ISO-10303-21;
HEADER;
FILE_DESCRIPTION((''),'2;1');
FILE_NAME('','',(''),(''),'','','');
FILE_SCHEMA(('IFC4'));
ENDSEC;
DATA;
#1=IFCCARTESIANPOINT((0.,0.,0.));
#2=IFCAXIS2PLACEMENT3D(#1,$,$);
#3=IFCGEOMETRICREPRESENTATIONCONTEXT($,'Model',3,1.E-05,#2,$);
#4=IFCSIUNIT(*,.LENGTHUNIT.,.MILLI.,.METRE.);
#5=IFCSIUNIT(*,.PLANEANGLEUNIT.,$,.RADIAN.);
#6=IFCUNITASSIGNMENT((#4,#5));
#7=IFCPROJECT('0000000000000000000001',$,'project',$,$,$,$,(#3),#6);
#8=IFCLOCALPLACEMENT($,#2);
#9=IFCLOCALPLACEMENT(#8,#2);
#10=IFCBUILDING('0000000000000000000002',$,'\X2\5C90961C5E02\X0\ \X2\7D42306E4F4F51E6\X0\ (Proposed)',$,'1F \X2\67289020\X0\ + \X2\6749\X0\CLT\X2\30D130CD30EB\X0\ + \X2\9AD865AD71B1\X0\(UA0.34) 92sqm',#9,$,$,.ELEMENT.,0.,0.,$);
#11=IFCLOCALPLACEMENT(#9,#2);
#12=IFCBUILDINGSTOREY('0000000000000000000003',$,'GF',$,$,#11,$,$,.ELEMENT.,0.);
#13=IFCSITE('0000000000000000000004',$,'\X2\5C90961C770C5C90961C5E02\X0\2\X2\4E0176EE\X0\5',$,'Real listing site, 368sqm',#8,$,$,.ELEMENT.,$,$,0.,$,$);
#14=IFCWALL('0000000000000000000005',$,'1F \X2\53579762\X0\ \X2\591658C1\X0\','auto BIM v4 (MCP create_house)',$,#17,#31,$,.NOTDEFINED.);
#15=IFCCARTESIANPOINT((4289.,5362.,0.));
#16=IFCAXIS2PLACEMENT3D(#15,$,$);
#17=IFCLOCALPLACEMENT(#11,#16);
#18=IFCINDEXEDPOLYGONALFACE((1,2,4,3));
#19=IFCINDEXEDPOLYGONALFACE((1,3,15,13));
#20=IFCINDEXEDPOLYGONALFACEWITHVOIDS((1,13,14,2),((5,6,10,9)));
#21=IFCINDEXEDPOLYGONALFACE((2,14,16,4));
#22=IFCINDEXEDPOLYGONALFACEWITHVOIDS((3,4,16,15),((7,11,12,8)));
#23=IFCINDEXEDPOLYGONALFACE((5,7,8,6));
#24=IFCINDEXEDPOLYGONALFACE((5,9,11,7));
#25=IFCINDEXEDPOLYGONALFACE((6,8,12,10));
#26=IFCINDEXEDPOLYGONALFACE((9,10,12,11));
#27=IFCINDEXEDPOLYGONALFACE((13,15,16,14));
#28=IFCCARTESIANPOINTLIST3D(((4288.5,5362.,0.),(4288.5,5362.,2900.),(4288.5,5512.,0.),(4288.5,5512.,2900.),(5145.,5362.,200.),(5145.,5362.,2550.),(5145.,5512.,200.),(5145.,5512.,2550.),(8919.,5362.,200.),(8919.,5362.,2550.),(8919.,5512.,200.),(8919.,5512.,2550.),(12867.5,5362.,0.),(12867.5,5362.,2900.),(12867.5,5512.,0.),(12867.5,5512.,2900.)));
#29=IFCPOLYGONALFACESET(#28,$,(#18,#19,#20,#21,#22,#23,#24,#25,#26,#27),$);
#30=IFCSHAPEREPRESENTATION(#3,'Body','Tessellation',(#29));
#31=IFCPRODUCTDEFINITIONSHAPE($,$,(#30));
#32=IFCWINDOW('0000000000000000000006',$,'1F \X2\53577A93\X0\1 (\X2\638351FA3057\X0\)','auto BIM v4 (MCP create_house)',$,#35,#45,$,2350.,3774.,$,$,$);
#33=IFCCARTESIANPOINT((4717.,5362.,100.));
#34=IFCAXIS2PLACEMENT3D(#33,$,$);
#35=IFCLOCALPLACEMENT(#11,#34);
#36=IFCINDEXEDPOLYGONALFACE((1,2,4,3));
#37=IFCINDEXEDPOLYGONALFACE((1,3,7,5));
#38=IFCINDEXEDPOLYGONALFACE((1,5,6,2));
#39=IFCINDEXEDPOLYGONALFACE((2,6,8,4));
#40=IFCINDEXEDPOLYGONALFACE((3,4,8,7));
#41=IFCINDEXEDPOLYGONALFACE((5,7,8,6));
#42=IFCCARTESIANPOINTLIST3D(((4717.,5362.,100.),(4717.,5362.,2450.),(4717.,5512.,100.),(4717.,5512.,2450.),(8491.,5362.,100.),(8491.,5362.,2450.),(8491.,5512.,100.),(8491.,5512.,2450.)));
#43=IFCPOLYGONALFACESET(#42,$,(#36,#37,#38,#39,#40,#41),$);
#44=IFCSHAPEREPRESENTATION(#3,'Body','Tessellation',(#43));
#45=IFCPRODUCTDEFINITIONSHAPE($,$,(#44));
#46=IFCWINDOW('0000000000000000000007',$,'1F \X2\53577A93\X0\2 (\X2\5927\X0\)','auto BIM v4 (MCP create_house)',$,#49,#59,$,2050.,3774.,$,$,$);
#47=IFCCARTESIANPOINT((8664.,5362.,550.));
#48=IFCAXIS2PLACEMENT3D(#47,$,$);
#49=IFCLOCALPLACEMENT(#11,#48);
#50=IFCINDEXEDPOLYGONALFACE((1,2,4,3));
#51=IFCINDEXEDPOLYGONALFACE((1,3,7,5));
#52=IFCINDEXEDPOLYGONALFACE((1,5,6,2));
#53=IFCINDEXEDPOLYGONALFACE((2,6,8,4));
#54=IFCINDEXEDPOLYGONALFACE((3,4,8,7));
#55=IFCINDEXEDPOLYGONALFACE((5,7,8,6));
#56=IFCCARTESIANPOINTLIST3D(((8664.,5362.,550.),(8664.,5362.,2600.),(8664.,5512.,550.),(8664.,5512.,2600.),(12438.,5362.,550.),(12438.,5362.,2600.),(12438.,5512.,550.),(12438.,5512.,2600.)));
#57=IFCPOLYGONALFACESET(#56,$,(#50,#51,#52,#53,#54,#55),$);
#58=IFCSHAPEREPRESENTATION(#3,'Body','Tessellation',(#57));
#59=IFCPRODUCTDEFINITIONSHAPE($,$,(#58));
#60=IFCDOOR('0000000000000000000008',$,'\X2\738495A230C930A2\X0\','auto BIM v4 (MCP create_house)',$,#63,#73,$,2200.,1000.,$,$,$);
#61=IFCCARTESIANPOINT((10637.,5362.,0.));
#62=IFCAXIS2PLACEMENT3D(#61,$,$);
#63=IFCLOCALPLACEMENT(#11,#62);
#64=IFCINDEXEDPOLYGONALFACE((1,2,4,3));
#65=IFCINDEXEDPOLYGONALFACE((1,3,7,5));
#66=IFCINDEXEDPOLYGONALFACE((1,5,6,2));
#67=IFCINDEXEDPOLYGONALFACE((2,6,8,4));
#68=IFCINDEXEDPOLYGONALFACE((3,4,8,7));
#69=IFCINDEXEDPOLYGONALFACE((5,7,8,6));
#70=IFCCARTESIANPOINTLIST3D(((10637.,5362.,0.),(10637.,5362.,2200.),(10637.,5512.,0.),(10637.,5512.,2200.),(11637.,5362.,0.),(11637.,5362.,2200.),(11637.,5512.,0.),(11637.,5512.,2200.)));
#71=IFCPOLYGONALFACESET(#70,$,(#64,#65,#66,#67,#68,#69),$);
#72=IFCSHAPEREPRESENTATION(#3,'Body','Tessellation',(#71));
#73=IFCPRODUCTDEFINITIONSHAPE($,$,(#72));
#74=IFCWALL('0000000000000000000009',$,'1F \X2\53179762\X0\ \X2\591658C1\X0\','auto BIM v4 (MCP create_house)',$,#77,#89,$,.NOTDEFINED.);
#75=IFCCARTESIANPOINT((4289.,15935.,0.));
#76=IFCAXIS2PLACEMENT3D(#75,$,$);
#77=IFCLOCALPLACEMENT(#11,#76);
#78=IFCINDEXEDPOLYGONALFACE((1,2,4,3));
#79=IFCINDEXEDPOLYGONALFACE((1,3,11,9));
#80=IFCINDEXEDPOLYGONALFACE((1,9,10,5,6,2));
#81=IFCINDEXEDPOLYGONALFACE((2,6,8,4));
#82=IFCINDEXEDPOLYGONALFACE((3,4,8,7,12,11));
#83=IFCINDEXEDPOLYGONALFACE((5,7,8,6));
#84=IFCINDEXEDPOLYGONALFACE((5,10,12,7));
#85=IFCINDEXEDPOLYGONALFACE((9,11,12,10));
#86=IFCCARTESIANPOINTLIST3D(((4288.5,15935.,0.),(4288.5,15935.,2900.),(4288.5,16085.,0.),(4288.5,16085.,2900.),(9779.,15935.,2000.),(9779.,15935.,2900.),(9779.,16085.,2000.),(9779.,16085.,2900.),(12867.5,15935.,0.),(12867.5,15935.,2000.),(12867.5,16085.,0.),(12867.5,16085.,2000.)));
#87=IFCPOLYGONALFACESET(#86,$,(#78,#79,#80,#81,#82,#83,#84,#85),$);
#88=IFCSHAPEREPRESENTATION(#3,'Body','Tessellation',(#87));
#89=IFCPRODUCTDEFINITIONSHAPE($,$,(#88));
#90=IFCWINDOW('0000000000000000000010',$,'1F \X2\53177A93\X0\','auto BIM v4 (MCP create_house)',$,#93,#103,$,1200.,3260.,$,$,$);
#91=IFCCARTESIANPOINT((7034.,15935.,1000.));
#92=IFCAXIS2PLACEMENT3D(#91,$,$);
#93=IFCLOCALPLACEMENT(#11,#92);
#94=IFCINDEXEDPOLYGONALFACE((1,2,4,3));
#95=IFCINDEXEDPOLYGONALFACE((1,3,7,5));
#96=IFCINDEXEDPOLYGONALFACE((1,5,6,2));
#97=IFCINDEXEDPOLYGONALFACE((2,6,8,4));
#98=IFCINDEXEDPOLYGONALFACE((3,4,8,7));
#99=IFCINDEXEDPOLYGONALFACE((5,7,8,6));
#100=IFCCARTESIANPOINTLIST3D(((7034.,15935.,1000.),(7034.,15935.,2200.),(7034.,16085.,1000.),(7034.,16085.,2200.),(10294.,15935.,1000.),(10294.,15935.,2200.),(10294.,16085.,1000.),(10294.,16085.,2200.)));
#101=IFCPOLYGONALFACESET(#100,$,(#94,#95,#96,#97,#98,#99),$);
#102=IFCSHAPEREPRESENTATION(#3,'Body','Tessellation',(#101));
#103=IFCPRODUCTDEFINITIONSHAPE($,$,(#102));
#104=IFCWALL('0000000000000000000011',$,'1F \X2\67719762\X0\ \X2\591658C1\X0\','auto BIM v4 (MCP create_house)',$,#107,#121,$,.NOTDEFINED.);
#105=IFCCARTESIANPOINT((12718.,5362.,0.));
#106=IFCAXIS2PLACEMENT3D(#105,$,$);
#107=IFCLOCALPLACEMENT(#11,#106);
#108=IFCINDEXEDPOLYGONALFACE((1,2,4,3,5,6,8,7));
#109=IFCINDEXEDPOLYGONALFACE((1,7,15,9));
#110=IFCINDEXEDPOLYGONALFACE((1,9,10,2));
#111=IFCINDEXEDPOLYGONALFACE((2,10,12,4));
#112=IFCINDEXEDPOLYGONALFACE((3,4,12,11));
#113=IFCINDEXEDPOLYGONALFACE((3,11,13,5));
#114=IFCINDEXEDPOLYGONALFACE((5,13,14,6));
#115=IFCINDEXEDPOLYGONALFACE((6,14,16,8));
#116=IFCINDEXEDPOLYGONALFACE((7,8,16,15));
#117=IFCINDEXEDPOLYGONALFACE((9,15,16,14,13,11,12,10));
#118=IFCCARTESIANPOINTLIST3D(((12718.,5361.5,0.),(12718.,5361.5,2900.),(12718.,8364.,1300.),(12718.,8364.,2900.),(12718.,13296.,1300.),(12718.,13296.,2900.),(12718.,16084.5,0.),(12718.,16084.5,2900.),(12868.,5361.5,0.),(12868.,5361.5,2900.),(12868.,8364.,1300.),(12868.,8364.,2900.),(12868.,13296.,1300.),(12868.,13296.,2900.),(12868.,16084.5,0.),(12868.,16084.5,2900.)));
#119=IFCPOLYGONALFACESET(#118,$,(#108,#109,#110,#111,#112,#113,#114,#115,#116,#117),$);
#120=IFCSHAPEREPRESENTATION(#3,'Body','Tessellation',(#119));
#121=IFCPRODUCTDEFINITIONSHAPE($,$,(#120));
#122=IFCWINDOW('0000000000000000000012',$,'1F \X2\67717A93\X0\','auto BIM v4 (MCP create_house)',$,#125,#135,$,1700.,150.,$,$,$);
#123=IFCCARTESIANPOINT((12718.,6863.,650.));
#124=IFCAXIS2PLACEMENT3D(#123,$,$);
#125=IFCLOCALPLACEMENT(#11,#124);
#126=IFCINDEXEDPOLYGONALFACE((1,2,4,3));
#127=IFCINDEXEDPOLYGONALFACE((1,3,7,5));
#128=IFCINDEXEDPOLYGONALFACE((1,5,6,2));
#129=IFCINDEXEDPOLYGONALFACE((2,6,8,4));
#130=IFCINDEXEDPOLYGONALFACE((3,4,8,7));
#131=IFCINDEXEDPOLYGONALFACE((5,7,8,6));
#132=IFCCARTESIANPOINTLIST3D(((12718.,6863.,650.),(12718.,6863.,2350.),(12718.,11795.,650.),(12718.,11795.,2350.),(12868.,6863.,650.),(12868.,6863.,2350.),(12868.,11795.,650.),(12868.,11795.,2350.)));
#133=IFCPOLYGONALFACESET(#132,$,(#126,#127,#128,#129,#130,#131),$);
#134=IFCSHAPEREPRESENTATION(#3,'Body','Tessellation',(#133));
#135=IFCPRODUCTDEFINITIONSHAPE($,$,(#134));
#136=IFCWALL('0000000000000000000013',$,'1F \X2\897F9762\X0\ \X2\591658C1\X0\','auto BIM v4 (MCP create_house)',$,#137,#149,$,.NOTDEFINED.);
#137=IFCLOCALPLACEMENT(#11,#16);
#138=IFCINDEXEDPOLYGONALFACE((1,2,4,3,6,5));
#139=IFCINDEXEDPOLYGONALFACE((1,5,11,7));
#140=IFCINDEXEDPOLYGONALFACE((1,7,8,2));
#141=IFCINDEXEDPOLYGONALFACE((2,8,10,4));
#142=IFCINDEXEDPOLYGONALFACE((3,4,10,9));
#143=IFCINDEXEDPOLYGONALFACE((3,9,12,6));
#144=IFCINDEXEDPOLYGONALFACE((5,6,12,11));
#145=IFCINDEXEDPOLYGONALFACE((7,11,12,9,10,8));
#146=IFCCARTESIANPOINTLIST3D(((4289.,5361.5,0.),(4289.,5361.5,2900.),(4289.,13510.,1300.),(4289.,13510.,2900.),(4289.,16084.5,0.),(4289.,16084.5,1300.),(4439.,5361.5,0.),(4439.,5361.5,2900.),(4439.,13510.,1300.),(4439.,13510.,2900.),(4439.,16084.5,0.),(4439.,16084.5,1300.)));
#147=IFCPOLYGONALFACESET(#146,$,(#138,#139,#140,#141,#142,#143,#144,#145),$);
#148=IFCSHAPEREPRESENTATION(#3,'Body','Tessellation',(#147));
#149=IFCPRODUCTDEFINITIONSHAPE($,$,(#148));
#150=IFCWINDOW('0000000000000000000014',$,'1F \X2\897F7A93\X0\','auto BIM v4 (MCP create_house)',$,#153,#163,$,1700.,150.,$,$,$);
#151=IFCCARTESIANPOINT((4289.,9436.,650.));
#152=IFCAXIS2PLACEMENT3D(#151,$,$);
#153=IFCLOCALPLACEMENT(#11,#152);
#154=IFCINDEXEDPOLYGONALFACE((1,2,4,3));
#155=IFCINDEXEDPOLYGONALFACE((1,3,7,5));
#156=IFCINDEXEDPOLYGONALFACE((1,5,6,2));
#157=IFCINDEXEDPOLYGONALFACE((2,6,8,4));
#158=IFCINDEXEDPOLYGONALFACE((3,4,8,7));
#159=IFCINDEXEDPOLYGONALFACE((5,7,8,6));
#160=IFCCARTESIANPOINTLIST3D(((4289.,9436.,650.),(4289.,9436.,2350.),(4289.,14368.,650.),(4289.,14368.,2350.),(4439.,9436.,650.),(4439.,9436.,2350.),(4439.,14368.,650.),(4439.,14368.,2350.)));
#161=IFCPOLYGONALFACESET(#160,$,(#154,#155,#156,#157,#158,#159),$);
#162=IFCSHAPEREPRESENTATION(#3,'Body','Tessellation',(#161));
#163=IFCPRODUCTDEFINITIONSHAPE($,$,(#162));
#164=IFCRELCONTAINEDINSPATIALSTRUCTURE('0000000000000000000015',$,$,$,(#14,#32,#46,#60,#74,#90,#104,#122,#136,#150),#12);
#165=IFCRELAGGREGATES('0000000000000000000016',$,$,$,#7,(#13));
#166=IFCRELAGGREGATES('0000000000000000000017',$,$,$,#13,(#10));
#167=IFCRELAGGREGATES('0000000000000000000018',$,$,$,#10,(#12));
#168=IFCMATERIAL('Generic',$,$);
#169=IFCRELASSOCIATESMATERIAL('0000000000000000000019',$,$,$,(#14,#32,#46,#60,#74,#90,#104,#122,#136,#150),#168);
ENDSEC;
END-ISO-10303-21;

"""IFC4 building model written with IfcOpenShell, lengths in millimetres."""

from ifc_helpers import new_model, si_unit, frame, frame_2d, origin, place, context, project, spatial, rectangle, extrude, material, element, fill, save


model = new_model("IFC4")

# Units and contexts
model_context = context("Model", 3, precision=1e-05, world=origin())
ifc_project = project(units=[si_unit("LENGTHUNIT", "METRE", prefix="MILLI"), si_unit("PLANEANGLEUNIT", "RADIAN")], contexts=[model_context])

# Site, building, storey
site_placement = place(None, origin())
site = spatial("IfcSite", under=ifc_project, at=site_placement, Name="岐阜県岐阜市2丁目5", ObjectType="Real listing site, 368sqm", CompositionType="ELEMENT", RefElevation=0.0)
building_placement = place(site_placement, origin())
building = spatial("IfcBuilding", under=site, at=building_placement, Name="岐阜市 終の住処 (Proposed)", ObjectType="1F 木造 + 杉CLTパネル + 高断熱(UA0.34) 92sqm", CompositionType="ELEMENT", ElevationOfRefHeight=0.0, ElevationOfTerrain=0.0)
storey_placement = place(building_placement, origin())
storey = spatial("IfcBuildingStorey", under=building, at=storey_placement, Name="GF", CompositionType="ELEMENT", Elevation=0.0)

# Shared definitions
ifc_material = material(Name="Generic")

# Wall, openings, windows, door
wall_1_placement = place(storey_placement, frame((4289.0, 5362.0, 0.0)))
wall_1 = element("IfcWall", 1, at=wall_1_placement, inside=storey, material=ifc_material, Name="1F 南面 外壁", Description="auto BIM v4 (MCP create_house)", PredefinedType="NOTDEFINED", context=model_context, shape_type="SweptSolid", body=[
    extrude(rectangle(XDim=8579.0, YDim=150.0, at=frame_2d((4289.0, 75.0))), frame((4289.0, 5362.0, 0.0)), (0.0, 0.0, 1.0), 2900.0),
])
opening_1_placement = place(storey_placement, frame((4717.0, 5362.0, 100.0)))
opening_1 = element("IfcOpeningElement", 2, at=opening_1_placement, cuts=wall_1, PredefinedType="NOTDEFINED", context=model_context, shape_type="SweptSolid", body=[
    extrude(rectangle(XDim=3774.0, YDim=150.0, at=frame_2d((1887.0, 75.0))), frame((4717.0, 5362.0, 100.0)), (0.0, 0.0, 1.0), 2350.0),
])
opening_2_placement = place(storey_placement, frame((8664.0, 5362.0, 550.0)))
opening_2 = element("IfcOpeningElement", 3, at=opening_2_placement, cuts=wall_1, PredefinedType="NOTDEFINED", context=model_context, shape_type="SweptSolid", body=[
    extrude(rectangle(XDim=3774.0, YDim=150.0, at=frame_2d((1887.0, 75.0))), frame((8664.0, 5362.0, 550.0)), (0.0, 0.0, 1.0), 2050.0),
])
opening_3_placement = place(storey_placement, frame((10637.0, 5362.0, 0.0)))
opening_3 = element("IfcOpeningElement", 4, at=opening_3_placement, cuts=wall_1, PredefinedType="NOTDEFINED", context=model_context, shape_type="SweptSolid", body=[
    extrude(rectangle(XDim=1000.0, YDim=150.0, at=frame_2d((500.0, 75.0))), frame((10637.0, 5362.0, 0.0)), (0.0, 0.0, 1.0), 2200.0),
])
window_1_placement = place(storey_placement, frame((4717.0, 5362.0, 100.0)))
window_1 = element("IfcWindow", 5, at=window_1_placement, inside=storey, material=ifc_material, Name="1F 南窓1 (掃出し)", Description="auto BIM v4 (MCP create_house)", OverallHeight=2350.0, OverallWidth=3774.0, context=model_context, shape_type="SweptSolid", body=[
    extrude(rectangle(XDim=3774.0, YDim=150.0, at=frame_2d((1887.0, 75.0))), frame((4717.0, 5362.0, 100.0)), (0.0, 0.0, 1.0), 2350.0),
])
fill(opening_1, window_1)
window_2_placement = place(storey_placement, frame((8664.0, 5362.0, 550.0)))
window_2 = element("IfcWindow", 6, at=window_2_placement, inside=storey, material=ifc_material, Name="1F 南窓2 (大)", Description="auto BIM v4 (MCP create_house)", OverallHeight=2050.0, OverallWidth=3774.0, context=model_context, shape_type="SweptSolid", body=[
    extrude(rectangle(XDim=3774.0, YDim=150.0, at=frame_2d((1887.0, 75.0))), frame((8664.0, 5362.0, 550.0)), (0.0, 0.0, 1.0), 2050.0),
])
fill(opening_2, window_2)
door_placement = place(storey_placement, frame((10637.0, 5362.0, 0.0)))
door = element("IfcDoor", 7, at=door_placement, inside=storey, material=ifc_material, Name="玄関ドア", Description="auto BIM v4 (MCP create_house)", OverallHeight=2200.0, OverallWidth=1000.0, context=model_context, shape_type="SweptSolid", body=[
    extrude(rectangle(XDim=1000.0, YDim=150.0, at=frame_2d((500.0, 75.0))), frame((10637.0, 5362.0, 0.0)), (0.0, 0.0, 1.0), 2200.0),
])
fill(opening_3, door)

# Walls, openings, windows
wall_2_placement = place(storey_placement, frame((4289.0, 15935.0, 0.0)))
wall_2 = element("IfcWall", 8, at=wall_2_placement, inside=storey, material=ifc_material, Name="1F 北面 外壁", Description="auto BIM v4 (MCP create_house)", PredefinedType="NOTDEFINED", context=model_context, shape_type="SweptSolid", body=[
    extrude(rectangle(XDim=8579.0, YDim=150.0, at=frame_2d((4289.0, 75.0))), frame((4289.0, 15935.0, 0.0)), (0.0, 0.0, 1.0), 2900.0),
])
opening_4_placement = place(storey_placement, frame((7034.0, 15935.0, 1000.0)))
opening_4 = element("IfcOpeningElement", 9, at=opening_4_placement, cuts=wall_2, PredefinedType="NOTDEFINED", context=model_context, shape_type="SweptSolid", body=[
    extrude(rectangle(XDim=3260.0, YDim=150.0, at=frame_2d((1630.0, 75.0))), frame((7034.0, 15935.0, 1000.0)), (0.0, 0.0, 1.0), 1200.0),
])
window_3_placement = place(storey_placement, frame((7034.0, 15935.0, 1000.0)))
window_3 = element("IfcWindow", 10, at=window_3_placement, inside=storey, material=ifc_material, Name="1F 北窓", Description="auto BIM v4 (MCP create_house)", OverallHeight=1200.0, OverallWidth=3260.0, context=model_context, shape_type="SweptSolid", body=[
    extrude(rectangle(XDim=3260.0, YDim=150.0, at=frame_2d((1630.0, 75.0))), frame((7034.0, 15935.0, 1000.0)), (0.0, 0.0, 1.0), 1200.0),
])
fill(opening_4, window_3)
wall_3_placement = place(storey_placement, frame((12718.0, 5362.0, 0.0)))
wall_3 = element("IfcWall", 11, at=wall_3_placement, inside=storey, material=ifc_material, Name="1F 東面 外壁", Description="auto BIM v4 (MCP create_house)", PredefinedType="NOTDEFINED", context=model_context, shape_type="SweptSolid", body=[
    extrude(rectangle(XDim=150.0, YDim=10723.0, at=frame_2d((75.0, 5361.0))), frame((12718.0, 5362.0, 0.0)), (0.0, 0.0, 1.0), 2900.0),
])
opening_5_placement = place(storey_placement, frame((12718.0, 6863.0, 650.0)))
opening_5 = element("IfcOpeningElement", 12, at=opening_5_placement, cuts=wall_3, PredefinedType="NOTDEFINED", context=model_context, shape_type="SweptSolid", body=[
    extrude(rectangle(XDim=150.0, YDim=4932.0, at=frame_2d((75.0, 2466.0))), frame((12718.0, 6863.0, 650.0)), (0.0, 0.0, 1.0), 1700.0),
])
window_4_placement = place(storey_placement, frame((12718.0, 6863.0, 650.0)))
window_4 = element("IfcWindow", 13, at=window_4_placement, inside=storey, material=ifc_material, Name="1F 東窓", Description="auto BIM v4 (MCP create_house)", OverallHeight=1700.0, OverallWidth=150.0, context=model_context, shape_type="SweptSolid", body=[
    extrude(rectangle(XDim=150.0, YDim=4932.0, at=frame_2d((75.0, 2466.0))), frame((12718.0, 6863.0, 650.0)), (0.0, 0.0, 1.0), 1700.0),
])
fill(opening_5, window_4)
wall_4_placement = place(storey_placement, frame((4289.0, 5362.0, 0.0)))
wall_4 = element("IfcWall", 14, at=wall_4_placement, inside=storey, material=ifc_material, Name="1F 西面 外壁", Description="auto BIM v4 (MCP create_house)", PredefinedType="NOTDEFINED", context=model_context, shape_type="SweptSolid", body=[
    extrude(rectangle(XDim=150.0, YDim=10723.0, at=frame_2d((75.0, 5361.0))), frame((4289.0, 5362.0, 0.0)), (0.0, 0.0, 1.0), 2900.0),
])
opening_6_placement = place(storey_placement, frame((4289.0, 9436.0, 650.0)))
opening_6 = element("IfcOpeningElement", 15, at=opening_6_placement, cuts=wall_4, PredefinedType="NOTDEFINED", context=model_context, shape_type="SweptSolid", body=[
    extrude(rectangle(XDim=150.0, YDim=4932.0, at=frame_2d((75.0, 2466.0))), frame((4289.0, 9436.0, 650.0)), (0.0, 0.0, 1.0), 1700.0),
])
window_5_placement = place(storey_placement, frame((4289.0, 9436.0, 650.0)))
window_5 = element("IfcWindow", 16, at=window_5_placement, inside=storey, material=ifc_material, Name="1F 西窓", Description="auto BIM v4 (MCP create_house)", OverallHeight=1700.0, OverallWidth=150.0, context=model_context, shape_type="SweptSolid", body=[
    extrude(rectangle(XDim=150.0, YDim=4932.0, at=frame_2d((75.0, 2466.0))), frame((4289.0, 9436.0, 650.0)), (0.0, 0.0, 1.0), 1700.0),
])
fill(opening_6, window_5)

save(model, "model.ifc")
